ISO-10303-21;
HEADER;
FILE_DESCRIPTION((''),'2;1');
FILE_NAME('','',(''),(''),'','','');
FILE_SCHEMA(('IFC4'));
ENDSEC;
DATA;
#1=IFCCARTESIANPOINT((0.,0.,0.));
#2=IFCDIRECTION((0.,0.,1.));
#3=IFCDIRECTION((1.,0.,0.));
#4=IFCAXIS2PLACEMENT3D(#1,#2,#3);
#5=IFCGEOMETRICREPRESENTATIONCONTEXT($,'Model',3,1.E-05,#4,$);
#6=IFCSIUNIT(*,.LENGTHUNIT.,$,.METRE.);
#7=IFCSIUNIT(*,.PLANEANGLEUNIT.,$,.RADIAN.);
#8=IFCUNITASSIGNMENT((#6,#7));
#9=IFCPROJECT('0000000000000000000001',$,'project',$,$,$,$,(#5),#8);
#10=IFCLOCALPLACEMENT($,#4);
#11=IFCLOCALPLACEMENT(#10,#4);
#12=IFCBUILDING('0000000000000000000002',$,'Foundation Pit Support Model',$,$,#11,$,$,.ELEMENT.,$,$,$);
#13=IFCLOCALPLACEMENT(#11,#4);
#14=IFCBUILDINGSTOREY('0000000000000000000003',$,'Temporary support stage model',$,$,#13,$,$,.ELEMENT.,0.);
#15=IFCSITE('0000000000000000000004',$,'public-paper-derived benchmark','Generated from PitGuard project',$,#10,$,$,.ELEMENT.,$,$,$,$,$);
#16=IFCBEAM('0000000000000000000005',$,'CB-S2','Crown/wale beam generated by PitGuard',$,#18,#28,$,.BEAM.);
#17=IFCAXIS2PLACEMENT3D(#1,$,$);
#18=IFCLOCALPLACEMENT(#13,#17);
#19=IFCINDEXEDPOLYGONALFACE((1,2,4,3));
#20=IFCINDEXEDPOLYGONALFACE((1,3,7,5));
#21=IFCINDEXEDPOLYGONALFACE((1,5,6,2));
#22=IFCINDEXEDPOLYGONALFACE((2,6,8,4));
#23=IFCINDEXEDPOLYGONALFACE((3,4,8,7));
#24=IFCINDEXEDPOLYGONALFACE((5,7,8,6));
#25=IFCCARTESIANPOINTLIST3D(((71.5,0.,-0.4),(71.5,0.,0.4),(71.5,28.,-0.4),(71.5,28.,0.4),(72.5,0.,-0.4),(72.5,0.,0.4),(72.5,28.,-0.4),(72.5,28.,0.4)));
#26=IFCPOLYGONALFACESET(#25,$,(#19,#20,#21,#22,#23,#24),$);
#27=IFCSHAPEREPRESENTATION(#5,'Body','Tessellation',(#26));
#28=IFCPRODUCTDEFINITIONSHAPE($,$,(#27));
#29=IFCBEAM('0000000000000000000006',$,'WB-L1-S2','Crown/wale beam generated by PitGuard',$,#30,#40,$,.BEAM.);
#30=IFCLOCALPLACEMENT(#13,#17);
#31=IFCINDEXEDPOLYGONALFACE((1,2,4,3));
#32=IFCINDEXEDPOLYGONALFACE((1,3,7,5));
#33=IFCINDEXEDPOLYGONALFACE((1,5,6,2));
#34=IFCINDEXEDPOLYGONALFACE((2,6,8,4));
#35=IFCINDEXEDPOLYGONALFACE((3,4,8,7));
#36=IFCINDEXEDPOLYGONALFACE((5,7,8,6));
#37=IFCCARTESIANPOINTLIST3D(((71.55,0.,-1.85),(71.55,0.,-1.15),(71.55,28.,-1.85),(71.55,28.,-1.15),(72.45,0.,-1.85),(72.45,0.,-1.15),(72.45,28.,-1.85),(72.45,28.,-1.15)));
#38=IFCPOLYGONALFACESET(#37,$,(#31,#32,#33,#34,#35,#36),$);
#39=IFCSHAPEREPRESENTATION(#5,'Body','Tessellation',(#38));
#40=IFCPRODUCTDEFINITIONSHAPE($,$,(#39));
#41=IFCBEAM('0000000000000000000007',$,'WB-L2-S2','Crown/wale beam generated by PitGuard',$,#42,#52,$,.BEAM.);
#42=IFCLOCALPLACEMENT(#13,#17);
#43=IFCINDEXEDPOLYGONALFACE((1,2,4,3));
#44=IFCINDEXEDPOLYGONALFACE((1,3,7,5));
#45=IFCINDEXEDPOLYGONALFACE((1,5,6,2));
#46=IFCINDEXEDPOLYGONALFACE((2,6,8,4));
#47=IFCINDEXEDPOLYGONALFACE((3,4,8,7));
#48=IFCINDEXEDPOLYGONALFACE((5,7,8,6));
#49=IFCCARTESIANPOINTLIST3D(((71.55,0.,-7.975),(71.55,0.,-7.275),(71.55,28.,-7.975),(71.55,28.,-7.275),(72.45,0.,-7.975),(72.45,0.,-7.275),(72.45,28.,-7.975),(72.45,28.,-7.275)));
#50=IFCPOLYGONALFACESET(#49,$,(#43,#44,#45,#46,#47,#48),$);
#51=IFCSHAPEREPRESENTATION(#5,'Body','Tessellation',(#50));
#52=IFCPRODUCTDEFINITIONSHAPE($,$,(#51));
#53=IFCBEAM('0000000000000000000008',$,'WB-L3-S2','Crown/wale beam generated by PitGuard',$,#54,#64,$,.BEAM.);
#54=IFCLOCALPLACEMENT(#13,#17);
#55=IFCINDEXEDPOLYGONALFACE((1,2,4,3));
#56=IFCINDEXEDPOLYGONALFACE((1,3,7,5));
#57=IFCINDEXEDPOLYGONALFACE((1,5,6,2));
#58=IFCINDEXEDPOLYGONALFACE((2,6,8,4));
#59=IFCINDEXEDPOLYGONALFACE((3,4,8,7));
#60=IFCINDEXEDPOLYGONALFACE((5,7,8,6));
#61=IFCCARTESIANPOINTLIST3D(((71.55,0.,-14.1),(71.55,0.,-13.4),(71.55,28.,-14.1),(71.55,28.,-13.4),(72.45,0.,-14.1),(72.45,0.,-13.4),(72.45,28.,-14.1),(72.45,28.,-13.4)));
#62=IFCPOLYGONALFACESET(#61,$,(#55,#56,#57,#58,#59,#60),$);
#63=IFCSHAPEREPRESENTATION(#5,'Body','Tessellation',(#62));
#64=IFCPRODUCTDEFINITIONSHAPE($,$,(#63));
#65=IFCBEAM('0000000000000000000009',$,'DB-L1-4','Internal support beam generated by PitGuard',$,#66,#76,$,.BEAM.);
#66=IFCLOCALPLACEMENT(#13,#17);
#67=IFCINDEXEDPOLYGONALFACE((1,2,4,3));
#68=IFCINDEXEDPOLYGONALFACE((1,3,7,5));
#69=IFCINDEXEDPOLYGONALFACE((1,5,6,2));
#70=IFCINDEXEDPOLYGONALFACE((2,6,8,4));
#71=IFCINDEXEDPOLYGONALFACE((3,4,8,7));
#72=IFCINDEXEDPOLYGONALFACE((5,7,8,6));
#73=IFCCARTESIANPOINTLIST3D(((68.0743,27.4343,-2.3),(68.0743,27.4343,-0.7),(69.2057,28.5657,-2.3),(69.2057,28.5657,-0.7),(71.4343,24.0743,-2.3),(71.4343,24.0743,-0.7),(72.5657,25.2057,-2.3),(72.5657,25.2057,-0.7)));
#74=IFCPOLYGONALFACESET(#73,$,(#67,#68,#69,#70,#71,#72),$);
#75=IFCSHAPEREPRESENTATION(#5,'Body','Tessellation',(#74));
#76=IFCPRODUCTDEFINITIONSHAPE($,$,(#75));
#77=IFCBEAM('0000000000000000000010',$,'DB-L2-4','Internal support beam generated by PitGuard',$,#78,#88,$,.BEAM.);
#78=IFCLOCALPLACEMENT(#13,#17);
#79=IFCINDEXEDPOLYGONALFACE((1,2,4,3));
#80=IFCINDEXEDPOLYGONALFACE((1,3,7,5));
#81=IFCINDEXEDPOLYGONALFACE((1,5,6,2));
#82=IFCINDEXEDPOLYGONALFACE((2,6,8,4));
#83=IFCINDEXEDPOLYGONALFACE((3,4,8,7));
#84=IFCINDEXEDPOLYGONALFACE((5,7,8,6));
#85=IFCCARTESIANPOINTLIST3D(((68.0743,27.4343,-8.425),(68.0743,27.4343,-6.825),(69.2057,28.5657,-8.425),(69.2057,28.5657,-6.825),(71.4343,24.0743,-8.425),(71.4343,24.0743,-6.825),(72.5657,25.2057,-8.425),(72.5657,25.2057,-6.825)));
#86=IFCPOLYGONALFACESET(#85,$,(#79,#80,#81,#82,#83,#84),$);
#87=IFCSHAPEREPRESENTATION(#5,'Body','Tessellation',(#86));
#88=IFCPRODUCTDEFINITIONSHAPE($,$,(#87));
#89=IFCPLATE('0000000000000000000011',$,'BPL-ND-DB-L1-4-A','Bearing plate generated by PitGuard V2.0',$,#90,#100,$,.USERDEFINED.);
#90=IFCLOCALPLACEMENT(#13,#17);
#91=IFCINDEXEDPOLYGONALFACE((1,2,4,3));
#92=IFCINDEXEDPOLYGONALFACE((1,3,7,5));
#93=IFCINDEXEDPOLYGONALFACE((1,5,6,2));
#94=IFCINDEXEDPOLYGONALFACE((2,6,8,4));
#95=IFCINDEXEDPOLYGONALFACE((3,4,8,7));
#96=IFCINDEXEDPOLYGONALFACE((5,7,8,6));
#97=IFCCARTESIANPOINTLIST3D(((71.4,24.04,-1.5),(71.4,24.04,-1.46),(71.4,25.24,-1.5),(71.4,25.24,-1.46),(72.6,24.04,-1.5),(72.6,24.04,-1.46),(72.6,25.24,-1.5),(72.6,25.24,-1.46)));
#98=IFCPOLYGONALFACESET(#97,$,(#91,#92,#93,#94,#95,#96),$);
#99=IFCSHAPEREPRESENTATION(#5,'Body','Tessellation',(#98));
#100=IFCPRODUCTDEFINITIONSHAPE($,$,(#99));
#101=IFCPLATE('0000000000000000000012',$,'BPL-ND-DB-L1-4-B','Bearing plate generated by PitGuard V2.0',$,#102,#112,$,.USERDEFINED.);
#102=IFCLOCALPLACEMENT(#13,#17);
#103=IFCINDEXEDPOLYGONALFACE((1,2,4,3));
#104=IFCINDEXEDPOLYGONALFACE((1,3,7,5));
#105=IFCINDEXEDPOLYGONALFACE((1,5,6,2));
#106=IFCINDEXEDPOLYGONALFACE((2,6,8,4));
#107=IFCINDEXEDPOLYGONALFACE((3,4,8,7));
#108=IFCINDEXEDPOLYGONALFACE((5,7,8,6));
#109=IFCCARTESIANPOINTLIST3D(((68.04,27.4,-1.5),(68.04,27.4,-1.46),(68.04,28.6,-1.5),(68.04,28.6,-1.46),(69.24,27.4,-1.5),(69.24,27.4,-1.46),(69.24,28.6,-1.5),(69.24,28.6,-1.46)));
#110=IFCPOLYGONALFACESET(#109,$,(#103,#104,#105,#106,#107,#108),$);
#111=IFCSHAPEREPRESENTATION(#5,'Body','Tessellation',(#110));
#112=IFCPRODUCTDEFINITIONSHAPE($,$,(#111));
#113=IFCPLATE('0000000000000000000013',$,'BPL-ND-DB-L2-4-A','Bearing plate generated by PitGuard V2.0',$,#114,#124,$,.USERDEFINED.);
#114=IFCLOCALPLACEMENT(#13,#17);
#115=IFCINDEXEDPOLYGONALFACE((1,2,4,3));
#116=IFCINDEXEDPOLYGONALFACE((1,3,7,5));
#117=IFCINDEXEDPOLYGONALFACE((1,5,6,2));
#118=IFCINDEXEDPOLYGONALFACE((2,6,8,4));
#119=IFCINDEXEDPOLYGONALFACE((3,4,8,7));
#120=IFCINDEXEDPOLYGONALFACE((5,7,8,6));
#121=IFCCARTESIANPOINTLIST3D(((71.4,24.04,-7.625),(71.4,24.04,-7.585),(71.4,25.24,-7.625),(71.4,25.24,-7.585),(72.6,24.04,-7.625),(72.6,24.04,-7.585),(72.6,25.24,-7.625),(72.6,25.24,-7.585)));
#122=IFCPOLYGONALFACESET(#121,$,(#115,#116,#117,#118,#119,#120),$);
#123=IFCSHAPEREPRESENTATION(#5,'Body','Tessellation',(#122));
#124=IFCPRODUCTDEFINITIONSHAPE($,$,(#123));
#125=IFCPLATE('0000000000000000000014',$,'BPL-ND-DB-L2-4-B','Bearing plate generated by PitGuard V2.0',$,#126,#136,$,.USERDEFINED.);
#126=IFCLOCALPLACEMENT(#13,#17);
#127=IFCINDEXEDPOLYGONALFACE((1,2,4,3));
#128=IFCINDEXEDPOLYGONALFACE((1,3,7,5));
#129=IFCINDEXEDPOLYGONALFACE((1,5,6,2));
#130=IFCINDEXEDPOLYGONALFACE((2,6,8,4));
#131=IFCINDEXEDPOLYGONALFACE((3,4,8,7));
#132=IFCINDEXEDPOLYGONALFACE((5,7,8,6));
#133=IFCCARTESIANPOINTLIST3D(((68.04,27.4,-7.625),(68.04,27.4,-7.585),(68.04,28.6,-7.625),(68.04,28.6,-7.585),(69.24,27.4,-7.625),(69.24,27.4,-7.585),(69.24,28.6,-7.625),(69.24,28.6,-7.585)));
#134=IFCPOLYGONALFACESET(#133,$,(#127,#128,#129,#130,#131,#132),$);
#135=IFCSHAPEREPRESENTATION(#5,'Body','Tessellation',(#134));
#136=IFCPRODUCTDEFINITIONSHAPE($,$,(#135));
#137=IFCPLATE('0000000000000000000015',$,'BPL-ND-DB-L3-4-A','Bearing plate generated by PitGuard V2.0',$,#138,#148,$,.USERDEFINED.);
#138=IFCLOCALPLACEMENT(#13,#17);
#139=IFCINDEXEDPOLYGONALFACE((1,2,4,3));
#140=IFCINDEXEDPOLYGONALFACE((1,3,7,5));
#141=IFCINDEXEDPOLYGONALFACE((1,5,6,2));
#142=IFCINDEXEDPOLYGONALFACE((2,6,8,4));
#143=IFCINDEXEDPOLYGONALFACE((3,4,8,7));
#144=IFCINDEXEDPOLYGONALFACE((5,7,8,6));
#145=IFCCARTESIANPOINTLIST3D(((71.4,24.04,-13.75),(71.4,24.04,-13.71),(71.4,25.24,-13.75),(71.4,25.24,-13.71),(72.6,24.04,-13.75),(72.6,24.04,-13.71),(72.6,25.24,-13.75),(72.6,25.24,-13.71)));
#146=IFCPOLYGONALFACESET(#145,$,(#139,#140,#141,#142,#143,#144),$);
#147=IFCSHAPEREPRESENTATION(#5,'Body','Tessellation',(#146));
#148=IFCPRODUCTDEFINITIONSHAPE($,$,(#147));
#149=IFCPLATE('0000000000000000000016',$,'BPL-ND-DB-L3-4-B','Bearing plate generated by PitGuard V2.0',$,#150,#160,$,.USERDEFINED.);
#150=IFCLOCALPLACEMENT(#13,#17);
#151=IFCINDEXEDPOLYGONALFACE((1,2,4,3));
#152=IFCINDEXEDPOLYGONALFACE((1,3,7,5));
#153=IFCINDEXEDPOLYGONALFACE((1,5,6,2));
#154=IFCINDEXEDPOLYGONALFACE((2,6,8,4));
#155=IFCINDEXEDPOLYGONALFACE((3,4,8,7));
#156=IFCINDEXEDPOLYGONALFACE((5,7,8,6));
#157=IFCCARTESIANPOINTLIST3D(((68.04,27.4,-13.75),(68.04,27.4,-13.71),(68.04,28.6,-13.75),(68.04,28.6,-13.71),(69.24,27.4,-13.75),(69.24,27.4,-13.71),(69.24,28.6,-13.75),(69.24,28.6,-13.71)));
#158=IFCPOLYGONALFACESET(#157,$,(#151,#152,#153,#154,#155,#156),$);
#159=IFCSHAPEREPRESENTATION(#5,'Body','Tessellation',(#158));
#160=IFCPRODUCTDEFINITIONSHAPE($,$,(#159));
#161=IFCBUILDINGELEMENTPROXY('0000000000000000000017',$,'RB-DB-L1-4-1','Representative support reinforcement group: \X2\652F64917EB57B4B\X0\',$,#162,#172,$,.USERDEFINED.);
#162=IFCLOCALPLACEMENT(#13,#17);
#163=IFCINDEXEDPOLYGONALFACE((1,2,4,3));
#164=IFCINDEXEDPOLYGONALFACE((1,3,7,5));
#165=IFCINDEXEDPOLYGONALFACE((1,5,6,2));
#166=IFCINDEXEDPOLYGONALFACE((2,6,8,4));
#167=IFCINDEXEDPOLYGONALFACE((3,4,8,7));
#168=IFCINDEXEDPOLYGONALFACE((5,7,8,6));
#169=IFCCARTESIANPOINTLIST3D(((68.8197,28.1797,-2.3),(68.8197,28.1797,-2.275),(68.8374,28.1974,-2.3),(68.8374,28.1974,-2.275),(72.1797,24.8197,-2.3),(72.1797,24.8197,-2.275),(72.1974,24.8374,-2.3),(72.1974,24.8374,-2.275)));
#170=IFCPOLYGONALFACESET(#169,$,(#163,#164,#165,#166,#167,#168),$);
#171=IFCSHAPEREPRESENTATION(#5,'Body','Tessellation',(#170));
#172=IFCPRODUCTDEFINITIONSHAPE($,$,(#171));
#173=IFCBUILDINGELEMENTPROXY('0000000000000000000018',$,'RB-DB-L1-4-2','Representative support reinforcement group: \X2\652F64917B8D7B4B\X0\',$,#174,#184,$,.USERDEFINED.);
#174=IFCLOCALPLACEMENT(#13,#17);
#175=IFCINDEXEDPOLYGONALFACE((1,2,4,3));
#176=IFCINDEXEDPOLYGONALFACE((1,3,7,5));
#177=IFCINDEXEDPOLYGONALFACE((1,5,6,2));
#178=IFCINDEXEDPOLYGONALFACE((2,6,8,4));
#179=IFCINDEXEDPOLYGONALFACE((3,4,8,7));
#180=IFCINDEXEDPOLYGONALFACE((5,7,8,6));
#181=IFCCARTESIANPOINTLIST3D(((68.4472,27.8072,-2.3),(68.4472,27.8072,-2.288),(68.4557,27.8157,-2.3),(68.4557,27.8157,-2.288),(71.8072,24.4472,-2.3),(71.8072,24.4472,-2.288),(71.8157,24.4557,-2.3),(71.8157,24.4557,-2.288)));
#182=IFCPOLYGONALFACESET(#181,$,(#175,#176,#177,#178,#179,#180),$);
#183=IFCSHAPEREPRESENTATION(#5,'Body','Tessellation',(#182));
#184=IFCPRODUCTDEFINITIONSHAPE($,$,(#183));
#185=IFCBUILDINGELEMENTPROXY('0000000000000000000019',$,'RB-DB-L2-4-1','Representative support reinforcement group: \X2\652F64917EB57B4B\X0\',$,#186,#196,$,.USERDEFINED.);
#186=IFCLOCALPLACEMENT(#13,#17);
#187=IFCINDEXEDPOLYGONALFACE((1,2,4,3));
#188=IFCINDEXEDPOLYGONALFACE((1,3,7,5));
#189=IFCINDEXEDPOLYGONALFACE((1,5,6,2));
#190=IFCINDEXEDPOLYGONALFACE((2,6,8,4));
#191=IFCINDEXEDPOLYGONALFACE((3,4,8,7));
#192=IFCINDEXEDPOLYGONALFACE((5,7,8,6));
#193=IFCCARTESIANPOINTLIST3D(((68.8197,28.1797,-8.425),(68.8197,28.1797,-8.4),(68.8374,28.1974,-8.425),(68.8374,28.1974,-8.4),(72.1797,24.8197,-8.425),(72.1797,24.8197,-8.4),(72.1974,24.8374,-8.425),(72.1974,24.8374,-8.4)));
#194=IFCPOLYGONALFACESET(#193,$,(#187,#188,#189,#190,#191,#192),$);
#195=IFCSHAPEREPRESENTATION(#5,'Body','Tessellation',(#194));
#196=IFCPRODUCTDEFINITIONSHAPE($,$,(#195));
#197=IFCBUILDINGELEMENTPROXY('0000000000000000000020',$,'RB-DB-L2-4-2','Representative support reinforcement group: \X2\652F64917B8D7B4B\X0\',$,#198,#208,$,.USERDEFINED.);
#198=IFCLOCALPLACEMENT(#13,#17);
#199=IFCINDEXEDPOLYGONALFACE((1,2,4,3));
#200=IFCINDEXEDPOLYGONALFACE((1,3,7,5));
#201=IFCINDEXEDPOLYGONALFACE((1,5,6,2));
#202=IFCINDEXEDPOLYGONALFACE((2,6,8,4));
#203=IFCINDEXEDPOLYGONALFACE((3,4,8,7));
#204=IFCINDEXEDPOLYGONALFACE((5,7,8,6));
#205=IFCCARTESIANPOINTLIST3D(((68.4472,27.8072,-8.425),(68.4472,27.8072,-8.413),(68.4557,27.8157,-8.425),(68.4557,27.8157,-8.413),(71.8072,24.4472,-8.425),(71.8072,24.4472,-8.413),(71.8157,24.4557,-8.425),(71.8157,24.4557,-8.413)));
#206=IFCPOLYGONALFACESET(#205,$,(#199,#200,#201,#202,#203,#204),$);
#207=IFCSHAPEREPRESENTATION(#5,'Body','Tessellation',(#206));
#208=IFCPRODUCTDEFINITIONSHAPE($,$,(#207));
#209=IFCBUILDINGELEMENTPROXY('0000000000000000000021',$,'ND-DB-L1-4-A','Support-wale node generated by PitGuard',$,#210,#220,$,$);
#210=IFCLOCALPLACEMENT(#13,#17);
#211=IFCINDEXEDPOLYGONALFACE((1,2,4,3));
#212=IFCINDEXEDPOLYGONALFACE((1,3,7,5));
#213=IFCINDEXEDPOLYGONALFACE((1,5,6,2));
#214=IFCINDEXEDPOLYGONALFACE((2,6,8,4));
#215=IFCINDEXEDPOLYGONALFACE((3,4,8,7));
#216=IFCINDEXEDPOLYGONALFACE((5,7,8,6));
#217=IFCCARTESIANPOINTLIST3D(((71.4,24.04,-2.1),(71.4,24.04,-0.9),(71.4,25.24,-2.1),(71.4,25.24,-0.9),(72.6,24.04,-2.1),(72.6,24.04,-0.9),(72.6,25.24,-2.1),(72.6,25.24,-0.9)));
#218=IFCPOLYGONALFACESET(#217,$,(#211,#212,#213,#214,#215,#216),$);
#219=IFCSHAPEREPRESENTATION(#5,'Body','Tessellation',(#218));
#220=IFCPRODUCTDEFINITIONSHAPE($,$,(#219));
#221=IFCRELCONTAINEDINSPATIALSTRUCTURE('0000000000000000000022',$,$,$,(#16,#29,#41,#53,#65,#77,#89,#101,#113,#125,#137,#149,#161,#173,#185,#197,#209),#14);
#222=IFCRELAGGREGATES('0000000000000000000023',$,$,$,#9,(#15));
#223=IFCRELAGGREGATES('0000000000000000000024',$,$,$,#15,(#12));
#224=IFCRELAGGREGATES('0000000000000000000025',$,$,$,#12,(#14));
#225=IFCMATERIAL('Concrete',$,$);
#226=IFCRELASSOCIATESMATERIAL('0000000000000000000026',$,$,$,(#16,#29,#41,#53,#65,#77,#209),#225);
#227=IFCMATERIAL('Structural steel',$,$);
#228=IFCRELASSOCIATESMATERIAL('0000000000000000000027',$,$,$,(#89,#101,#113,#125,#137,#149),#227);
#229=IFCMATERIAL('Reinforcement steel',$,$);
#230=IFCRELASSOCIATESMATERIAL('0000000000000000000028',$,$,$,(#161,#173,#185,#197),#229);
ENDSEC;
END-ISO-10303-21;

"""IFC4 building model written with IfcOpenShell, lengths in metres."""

from ifc_helpers import new_model, si_unit, frame, origin_with_axes, origin_2d, place, context, project, spatial, rectangle, extrude, material, element, save


model = new_model("IFC4")

# Units and contexts
model_context = context("Model", 3, precision=1e-05, world=origin_with_axes())
ifc_project = project(units=[si_unit("LENGTHUNIT", "METRE"), si_unit("PLANEANGLEUNIT", "RADIAN")], contexts=[model_context])

# Site, building, storey
site_placement = place(None, origin_with_axes())
site = spatial("IfcSite", under=ifc_project, at=site_placement, Name="public-paper-derived benchmark", Description="Generated from PitGuard project", CompositionType="ELEMENT")
building_placement = place(site_placement, origin_with_axes())
building = spatial("IfcBuilding", under=site, at=building_placement, Name="Foundation Pit Support Model", CompositionType="ELEMENT")
storey_placement = place(building_placement, origin_with_axes())
storey = spatial("IfcBuildingStorey", under=building, at=storey_placement, Name="Temporary support stage model", CompositionType="ELEMENT", Elevation=0.0)

# Beams
ifc_material_1 = material(Name="Concrete")
beam_placement = place(storey_placement, frame((72.0, 14.0, -0.4), z_axis=(0.0, 0.0, 1.0), x_axis=(0.0, 1.0, 0.0)))
element("IfcBeam", 1, at=beam_placement, inside=storey, material=ifc_material_1, Name="CB-S2", Description="Crown/wale beam generated by PitGuard", PredefinedType="BEAM", context=model_context, shape_type="SweptSolid", body=[
    extrude(rectangle(XDim=28.0, YDim=1.0, at=origin_2d()), origin_with_axes(), (0.0, 0.0, 1.0), 0.8),
])
for number, where, z_axis, x_axis, name in (
    (2, (72.0, 14.0, -1.85), (0.0, 0.0, 1.0), (0.0, 1.0, 0.0), "WB-L1-S2"),
    (3, (72.0, 14.0, -7.975), (0.0, 0.0, 1.0), (0.0, 1.0, 0.0), "WB-L2-S2"),
    (4, (72.0, 14.0, -14.1), (0.0, 0.0, 1.0), (0.0, 1.0, 0.0), "WB-L3-S2"),
):
    element("IfcBeam", number, at=place(storey_placement, frame(where, z_axis=z_axis, x_axis=x_axis)), inside=storey, material=ifc_material_1, Name=name, Description="Crown/wale beam generated by PitGuard", PredefinedType="BEAM", context=model_context, shape_type="SweptSolid", body=[
        extrude(rectangle(XDim=28.0, YDim=0.9, at=origin_2d()), origin_with_axes(), (0.0, 0.0, 1.0), 0.7),
    ])
for number, where, z_axis, x_axis, name in (
    (5, (70.32, 26.32, -2.3), (0.0, 0.0, 1.0), (-0.707107, 0.707107, 0.0), "DB-L1-4"),
    (6, (70.32, 26.32, -8.425), (0.0, 0.0, 1.0), (-0.707107, 0.707107, 0.0), "DB-L2-4"),
):
    element("IfcBeam", number, at=place(storey_placement, frame(where, z_axis=z_axis, x_axis=x_axis)), inside=storey, material=ifc_material_1, Name=name, Description="Internal support beam generated by PitGuard", PredefinedType="BEAM", context=model_context, shape_type="SweptSolid", body=[
        extrude(rectangle(XDim=4.7518, YDim=1.6, at=origin_2d()), origin_with_axes(), (0.0, 0.0, 1.0), 1.6),
    ])

# Plates
ifc_material_2 = material(Name="Structural steel")
for number, where, z_axis, x_axis, name in (
    (7, (72.0, 24.64, -1.5), (0.0, 0.0, 1.0), (1.0, 0.0, 0.0), "BPL-ND-DB-L1-4-A"),
    (8, (68.64, 28.0, -1.5), (0.0, 0.0, 1.0), (1.0, 0.0, 0.0), "BPL-ND-DB-L1-4-B"),
    (9, (72.0, 24.64, -7.625), (0.0, 0.0, 1.0), (1.0, 0.0, 0.0), "BPL-ND-DB-L2-4-A"),
    (10, (68.64, 28.0, -7.625), (0.0, 0.0, 1.0), (1.0, 0.0, 0.0), "BPL-ND-DB-L2-4-B"),
    (11, (72.0, 24.64, -13.75), (0.0, 0.0, 1.0), (1.0, 0.0, 0.0), "BPL-ND-DB-L3-4-A"),
    (12, (68.64, 28.0, -13.75), (0.0, 0.0, 1.0), (1.0, 0.0, 0.0), "BPL-ND-DB-L3-4-B"),
):
    element("IfcPlate", number, at=place(storey_placement, frame(where, z_axis=z_axis, x_axis=x_axis)), inside=storey, material=ifc_material_2, Name=name, Description="Bearing plate generated by PitGuard V2.0", PredefinedType="USERDEFINED", context=model_context, shape_type="SweptSolid", body=[
        extrude(rectangle(XDim=1.2, YDim=1.2, at=origin_2d()), origin_with_axes(), (0.0, 0.0, 1.0), 0.04),
    ])

# Building element proxies
ifc_material_3 = material(Name="Reinforcement steel")
proxy_1_placement = place(storey_placement, frame((70.5086, 26.5086, -2.3), z_axis=(0.0, 0.0, 1.0), x_axis=(-0.707107, 0.707107, 0.0)))
element("IfcBuildingElementProxy", 13, at=proxy_1_placement, inside=storey, material=ifc_material_3, Name="RB-DB-L1-4-1", Description="Representative support reinforcement group: 支撑纵筋", PredefinedType="USERDEFINED", context=model_context, shape_type="SweptSolid", body=[
    extrude(rectangle(XDim=4.7518, YDim=0.025, at=origin_2d()), origin_with_axes(), (0.0, 0.0, 1.0), 0.025),
])
proxy_2_placement = place(storey_placement, frame((70.1314, 26.1314, -2.3), z_axis=(0.0, 0.0, 1.0), x_axis=(-0.707107, 0.707107, 0.0)))
element("IfcBuildingElementProxy", 14, at=proxy_2_placement, inside=storey, material=ifc_material_3, Name="RB-DB-L1-4-2", Description="Representative support reinforcement group: 支撑箍筋", PredefinedType="USERDEFINED", context=model_context, shape_type="SweptSolid", body=[
    extrude(rectangle(XDim=4.7518, YDim=0.012, at=origin_2d()), origin_with_axes(), (0.0, 0.0, 1.0), 0.012),
])
proxy_3_placement = place(storey_placement, frame((70.5086, 26.5086, -8.425), z_axis=(0.0, 0.0, 1.0), x_axis=(-0.707107, 0.707107, 0.0)))
element("IfcBuildingElementProxy", 15, at=proxy_3_placement, inside=storey, material=ifc_material_3, Name="RB-DB-L2-4-1", Description="Representative support reinforcement group: 支撑纵筋", PredefinedType="USERDEFINED", context=model_context, shape_type="SweptSolid", body=[
    extrude(rectangle(XDim=4.7518, YDim=0.025, at=origin_2d()), origin_with_axes(), (0.0, 0.0, 1.0), 0.025),
])
proxy_4_placement = place(storey_placement, frame((70.1314, 26.1314, -8.425), z_axis=(0.0, 0.0, 1.0), x_axis=(-0.707107, 0.707107, 0.0)))
element("IfcBuildingElementProxy", 16, at=proxy_4_placement, inside=storey, material=ifc_material_3, Name="RB-DB-L2-4-2", Description="Representative support reinforcement group: 支撑箍筋", PredefinedType="USERDEFINED", context=model_context, shape_type="SweptSolid", body=[
    extrude(rectangle(XDim=4.7518, YDim=0.012, at=origin_2d()), origin_with_axes(), (0.0, 0.0, 1.0), 0.012),
])
proxy_5_placement = place(storey_placement, frame((72.0, 24.64, -2.1), z_axis=(0.0, 0.0, 1.0), x_axis=(1.0, 0.0, 0.0)))
element("IfcBuildingElementProxy", 17, at=proxy_5_placement, inside=storey, material=ifc_material_1, Name="ND-DB-L1-4-A", Description="Support-wale node generated by PitGuard", context=model_context, shape_type="SweptSolid", body=[
    extrude(rectangle(XDim=1.2, YDim=1.2, at=origin_2d()), origin_with_axes(), (0.0, 0.0, 1.0), 1.2),
])

save(model, "model.ifc")
